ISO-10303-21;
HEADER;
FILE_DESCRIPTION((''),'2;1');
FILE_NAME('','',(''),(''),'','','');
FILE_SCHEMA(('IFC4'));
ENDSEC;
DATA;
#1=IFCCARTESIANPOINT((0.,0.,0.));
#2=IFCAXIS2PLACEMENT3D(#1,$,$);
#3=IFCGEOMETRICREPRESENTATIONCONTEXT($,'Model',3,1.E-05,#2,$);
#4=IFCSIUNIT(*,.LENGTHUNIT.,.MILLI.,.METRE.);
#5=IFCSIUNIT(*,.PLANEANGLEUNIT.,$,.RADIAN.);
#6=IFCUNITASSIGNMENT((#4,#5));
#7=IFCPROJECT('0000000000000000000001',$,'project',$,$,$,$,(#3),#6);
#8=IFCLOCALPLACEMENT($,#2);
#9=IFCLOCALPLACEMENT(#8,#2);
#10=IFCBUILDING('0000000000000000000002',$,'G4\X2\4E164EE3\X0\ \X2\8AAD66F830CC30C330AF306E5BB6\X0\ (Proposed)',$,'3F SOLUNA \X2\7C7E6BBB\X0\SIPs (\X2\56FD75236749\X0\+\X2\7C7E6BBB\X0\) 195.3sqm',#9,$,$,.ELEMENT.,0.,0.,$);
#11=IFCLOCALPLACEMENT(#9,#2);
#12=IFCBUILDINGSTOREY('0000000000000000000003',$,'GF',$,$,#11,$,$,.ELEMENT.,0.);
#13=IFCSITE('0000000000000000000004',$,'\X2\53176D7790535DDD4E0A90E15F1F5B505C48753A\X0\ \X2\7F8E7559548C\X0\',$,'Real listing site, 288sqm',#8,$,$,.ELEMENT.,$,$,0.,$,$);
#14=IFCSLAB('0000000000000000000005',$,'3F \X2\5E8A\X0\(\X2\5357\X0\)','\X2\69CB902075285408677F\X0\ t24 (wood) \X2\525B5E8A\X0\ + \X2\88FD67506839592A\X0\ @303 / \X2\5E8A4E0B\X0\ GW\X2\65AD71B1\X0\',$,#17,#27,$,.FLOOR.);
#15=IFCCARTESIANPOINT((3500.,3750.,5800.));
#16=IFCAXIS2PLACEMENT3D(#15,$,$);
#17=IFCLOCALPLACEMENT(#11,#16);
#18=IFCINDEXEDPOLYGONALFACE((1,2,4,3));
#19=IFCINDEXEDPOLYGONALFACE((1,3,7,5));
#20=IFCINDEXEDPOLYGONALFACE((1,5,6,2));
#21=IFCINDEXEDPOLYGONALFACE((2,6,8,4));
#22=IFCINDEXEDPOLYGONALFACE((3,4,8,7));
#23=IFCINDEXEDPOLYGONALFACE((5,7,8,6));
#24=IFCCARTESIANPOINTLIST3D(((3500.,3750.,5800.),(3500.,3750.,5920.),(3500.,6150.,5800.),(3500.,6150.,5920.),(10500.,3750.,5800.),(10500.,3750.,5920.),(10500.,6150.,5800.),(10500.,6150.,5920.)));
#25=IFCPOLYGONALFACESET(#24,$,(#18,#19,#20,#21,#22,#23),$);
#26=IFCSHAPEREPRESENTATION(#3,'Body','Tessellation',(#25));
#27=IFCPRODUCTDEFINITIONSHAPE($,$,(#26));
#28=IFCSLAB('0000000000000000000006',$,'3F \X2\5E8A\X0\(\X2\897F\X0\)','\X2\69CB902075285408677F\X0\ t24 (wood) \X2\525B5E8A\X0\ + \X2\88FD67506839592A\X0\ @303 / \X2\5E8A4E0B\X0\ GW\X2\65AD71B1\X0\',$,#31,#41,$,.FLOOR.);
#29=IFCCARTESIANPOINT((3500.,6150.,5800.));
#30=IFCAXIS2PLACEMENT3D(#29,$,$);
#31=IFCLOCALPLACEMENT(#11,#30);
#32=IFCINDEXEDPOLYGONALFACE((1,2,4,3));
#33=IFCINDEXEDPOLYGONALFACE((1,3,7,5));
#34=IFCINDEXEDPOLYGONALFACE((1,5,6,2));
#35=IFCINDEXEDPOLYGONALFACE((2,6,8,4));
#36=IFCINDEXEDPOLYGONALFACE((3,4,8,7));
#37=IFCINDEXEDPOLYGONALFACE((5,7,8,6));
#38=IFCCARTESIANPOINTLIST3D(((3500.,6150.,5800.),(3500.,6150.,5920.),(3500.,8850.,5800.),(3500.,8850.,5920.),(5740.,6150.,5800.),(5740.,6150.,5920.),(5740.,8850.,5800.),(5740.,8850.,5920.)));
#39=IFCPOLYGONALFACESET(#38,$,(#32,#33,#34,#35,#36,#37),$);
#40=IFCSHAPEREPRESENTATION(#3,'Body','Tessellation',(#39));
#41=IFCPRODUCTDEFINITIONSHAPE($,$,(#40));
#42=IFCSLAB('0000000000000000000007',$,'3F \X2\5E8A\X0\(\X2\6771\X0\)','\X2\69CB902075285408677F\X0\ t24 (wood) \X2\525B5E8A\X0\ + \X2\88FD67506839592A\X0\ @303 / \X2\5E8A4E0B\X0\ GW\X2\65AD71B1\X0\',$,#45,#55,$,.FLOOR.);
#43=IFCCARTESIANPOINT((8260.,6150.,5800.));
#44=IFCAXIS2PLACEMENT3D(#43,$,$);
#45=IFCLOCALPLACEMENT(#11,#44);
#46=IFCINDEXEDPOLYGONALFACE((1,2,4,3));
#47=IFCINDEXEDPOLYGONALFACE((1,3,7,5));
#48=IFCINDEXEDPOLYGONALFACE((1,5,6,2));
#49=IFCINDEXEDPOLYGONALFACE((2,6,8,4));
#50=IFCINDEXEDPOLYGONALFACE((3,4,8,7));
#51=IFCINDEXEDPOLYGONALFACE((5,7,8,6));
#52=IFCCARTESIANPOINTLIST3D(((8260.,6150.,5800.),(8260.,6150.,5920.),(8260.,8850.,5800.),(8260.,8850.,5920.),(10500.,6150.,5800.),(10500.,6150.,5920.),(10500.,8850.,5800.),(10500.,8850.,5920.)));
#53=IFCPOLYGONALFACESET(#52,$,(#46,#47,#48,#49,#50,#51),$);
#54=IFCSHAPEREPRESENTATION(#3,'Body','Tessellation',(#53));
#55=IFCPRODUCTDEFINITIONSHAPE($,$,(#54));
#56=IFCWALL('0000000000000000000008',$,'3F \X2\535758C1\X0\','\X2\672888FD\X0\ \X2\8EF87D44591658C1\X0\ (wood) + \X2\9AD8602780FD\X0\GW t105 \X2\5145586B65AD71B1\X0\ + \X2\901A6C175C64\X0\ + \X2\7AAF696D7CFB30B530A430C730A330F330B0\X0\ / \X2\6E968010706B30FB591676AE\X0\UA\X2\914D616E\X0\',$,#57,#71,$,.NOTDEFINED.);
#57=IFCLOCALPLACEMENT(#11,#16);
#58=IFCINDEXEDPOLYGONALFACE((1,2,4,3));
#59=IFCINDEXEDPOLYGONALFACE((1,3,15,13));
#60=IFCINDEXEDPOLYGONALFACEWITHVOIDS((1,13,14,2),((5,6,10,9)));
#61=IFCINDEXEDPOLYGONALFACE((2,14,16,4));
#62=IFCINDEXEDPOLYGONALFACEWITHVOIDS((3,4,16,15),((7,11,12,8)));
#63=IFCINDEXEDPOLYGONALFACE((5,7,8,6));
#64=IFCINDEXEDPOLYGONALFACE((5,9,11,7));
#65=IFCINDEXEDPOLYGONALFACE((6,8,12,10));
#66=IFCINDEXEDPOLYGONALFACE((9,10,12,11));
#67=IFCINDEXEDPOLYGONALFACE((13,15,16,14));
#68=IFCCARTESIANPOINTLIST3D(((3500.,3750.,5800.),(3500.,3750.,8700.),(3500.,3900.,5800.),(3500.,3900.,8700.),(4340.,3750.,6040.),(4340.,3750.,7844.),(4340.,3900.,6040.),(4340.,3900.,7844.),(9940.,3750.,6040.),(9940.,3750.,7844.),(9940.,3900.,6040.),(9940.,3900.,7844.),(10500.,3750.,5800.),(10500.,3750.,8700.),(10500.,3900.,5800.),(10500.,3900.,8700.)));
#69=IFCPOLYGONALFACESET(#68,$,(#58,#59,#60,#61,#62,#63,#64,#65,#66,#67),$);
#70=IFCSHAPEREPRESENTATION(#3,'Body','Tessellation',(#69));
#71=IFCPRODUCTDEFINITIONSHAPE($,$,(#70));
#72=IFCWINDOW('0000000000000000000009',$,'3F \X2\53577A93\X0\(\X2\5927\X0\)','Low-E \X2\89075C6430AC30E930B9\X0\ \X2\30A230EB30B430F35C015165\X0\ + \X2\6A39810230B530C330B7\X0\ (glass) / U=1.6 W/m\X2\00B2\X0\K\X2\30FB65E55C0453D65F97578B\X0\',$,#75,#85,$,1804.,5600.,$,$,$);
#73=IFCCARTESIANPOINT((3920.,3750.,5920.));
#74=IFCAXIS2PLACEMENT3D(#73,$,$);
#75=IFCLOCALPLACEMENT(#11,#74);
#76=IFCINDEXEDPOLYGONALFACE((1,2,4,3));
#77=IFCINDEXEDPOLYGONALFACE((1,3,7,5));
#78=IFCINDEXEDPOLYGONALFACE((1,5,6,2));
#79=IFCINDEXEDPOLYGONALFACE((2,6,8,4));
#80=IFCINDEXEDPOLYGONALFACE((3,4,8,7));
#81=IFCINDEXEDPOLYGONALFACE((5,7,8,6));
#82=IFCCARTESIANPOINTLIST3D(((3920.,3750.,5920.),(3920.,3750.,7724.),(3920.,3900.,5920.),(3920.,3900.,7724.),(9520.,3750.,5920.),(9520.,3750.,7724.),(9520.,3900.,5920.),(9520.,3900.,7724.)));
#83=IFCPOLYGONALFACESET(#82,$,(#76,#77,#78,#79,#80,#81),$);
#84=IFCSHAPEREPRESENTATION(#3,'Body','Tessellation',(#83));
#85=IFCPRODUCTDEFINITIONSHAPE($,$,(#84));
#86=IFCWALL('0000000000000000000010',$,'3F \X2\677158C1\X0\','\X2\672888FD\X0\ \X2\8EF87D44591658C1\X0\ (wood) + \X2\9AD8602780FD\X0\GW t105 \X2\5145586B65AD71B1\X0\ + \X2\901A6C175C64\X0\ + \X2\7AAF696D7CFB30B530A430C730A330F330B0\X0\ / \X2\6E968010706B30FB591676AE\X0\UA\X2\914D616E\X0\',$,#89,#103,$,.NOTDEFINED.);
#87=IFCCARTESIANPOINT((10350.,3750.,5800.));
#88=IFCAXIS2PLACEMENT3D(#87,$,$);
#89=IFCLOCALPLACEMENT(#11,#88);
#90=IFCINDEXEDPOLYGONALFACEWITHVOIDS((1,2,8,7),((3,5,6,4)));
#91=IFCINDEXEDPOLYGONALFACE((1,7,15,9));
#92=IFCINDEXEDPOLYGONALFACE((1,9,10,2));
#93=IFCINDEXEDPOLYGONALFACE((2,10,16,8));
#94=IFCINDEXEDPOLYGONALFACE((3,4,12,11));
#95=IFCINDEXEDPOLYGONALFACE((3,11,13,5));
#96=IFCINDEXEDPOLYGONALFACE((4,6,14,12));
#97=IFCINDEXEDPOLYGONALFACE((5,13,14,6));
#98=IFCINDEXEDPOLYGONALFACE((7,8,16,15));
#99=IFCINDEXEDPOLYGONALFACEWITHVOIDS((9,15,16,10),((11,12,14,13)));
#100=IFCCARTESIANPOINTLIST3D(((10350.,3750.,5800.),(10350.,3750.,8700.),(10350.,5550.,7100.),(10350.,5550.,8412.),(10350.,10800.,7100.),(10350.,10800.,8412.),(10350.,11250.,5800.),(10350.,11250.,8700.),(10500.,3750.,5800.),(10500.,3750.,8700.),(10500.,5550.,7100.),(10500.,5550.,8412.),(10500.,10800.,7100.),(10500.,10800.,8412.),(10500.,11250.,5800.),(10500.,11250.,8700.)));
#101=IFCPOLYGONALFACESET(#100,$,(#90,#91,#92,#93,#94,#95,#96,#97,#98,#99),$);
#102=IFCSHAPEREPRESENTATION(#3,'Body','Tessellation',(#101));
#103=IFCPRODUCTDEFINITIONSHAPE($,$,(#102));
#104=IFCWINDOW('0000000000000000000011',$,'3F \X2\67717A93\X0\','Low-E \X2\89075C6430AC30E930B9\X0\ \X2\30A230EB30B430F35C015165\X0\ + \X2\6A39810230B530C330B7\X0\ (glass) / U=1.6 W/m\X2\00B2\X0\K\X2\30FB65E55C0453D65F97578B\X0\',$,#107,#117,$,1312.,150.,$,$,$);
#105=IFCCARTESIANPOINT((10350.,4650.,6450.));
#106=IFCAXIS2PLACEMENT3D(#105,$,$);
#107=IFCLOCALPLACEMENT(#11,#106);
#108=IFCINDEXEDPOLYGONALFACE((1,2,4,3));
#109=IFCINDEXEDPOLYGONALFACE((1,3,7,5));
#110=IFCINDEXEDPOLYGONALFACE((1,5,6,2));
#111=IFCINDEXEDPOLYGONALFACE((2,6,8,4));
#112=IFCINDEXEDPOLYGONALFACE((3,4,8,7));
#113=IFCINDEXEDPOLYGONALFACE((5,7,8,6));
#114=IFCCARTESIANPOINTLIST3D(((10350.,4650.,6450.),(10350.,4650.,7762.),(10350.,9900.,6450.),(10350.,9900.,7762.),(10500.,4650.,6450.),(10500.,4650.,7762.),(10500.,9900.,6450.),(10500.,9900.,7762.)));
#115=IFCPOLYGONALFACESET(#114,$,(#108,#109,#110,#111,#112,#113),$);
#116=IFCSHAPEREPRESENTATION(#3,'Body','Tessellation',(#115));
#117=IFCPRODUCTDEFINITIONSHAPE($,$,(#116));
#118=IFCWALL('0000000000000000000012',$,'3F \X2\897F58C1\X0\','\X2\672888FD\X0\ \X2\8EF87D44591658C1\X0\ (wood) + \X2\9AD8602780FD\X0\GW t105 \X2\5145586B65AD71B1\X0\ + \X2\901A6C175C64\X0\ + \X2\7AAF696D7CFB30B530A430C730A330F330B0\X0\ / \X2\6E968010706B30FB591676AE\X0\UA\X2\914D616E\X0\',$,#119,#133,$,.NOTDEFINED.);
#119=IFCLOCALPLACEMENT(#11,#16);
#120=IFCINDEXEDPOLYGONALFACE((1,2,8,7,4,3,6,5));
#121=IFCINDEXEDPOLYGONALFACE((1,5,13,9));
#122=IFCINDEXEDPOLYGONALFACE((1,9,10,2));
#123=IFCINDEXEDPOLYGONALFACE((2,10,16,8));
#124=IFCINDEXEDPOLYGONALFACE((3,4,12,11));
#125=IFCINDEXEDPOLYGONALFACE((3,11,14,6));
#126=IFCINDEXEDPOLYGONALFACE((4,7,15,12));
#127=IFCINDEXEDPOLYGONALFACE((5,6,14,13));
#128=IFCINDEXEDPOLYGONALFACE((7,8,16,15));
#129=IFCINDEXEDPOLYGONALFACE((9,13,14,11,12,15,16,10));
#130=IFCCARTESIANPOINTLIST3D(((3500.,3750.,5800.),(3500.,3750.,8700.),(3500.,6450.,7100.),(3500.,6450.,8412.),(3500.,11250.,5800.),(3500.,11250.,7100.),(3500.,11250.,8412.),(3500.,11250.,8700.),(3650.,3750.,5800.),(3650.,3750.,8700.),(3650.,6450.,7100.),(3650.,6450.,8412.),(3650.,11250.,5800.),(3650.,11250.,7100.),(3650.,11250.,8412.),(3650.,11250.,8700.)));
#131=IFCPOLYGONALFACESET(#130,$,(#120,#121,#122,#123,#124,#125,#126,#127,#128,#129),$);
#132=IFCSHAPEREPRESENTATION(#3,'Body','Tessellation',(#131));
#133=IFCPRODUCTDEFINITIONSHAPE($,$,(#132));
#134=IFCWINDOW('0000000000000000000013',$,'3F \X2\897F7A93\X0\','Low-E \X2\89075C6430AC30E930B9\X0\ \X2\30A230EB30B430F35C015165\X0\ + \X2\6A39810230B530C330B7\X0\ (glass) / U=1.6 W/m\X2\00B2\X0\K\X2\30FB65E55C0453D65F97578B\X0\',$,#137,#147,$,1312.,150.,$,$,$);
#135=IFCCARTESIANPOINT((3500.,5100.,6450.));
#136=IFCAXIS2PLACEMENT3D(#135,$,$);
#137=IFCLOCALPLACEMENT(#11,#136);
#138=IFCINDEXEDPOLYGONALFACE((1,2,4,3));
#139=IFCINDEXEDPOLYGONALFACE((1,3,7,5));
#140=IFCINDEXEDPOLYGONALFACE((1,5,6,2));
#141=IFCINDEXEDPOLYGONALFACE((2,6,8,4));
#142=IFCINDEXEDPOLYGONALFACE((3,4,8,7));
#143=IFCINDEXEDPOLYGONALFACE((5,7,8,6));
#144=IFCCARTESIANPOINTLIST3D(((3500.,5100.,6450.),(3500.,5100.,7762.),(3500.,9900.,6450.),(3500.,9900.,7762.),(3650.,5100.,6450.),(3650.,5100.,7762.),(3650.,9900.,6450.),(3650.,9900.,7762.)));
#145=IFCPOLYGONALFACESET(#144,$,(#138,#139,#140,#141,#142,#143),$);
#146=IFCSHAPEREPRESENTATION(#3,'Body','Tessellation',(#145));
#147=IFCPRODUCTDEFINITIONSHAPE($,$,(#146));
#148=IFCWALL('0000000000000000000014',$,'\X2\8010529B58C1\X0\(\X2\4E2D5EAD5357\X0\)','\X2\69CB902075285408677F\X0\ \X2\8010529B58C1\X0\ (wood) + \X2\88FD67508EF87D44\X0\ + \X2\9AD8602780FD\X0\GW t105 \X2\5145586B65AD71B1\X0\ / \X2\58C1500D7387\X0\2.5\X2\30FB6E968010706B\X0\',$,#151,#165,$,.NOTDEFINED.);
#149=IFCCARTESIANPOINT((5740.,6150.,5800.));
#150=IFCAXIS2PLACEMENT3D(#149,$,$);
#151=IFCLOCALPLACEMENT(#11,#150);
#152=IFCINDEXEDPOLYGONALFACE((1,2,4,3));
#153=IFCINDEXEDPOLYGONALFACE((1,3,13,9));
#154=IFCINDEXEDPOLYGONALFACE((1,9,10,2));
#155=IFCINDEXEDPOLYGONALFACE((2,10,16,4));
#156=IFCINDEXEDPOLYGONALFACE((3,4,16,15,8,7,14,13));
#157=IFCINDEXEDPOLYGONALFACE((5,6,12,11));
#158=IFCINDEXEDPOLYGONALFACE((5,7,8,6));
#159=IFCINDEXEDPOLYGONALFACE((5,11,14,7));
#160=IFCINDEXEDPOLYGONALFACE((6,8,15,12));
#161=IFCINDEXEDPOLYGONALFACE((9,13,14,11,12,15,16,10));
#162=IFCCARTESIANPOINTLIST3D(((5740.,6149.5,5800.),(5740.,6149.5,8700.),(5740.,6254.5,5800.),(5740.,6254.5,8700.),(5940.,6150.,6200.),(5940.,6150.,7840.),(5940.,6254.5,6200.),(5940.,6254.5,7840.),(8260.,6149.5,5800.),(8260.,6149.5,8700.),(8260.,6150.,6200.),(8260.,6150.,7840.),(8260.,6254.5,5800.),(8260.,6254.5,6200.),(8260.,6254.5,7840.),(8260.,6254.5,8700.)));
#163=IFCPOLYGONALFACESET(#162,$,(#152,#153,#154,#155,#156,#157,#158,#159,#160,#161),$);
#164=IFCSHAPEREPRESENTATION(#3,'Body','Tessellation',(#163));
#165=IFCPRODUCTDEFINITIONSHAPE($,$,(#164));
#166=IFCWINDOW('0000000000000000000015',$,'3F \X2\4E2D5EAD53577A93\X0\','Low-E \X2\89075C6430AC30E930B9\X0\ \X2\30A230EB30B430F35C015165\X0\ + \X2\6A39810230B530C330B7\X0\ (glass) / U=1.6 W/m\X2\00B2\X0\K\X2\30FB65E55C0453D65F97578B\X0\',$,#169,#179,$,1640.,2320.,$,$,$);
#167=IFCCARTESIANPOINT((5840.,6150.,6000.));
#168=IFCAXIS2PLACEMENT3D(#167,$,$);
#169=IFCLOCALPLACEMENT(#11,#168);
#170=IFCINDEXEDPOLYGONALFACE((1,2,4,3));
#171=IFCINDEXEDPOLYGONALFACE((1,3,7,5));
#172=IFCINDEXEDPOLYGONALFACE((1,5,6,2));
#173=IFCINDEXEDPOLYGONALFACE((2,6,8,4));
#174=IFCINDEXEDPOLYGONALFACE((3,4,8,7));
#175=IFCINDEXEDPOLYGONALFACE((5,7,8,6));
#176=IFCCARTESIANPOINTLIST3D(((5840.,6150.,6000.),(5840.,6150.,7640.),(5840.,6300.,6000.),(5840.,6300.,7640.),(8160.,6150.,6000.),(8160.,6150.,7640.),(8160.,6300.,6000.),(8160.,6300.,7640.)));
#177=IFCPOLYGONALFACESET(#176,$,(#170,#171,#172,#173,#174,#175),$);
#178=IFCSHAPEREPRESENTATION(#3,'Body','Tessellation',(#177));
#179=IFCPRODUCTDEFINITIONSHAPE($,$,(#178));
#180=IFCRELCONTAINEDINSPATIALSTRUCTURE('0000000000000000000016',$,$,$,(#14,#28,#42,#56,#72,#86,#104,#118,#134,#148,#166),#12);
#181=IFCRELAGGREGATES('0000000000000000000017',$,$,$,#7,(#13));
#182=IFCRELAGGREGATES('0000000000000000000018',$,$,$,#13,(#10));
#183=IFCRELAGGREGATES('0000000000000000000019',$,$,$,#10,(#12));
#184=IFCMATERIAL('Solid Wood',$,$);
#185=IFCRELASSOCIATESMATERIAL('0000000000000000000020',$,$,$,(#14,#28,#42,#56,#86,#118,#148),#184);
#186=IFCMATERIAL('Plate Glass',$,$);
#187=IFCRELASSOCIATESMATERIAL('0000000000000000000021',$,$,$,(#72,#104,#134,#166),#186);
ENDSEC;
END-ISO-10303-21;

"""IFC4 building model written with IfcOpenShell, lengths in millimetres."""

from ifc_helpers import new_model, si_unit, frame, frame_2d, origin, place, context, project, spatial, rectangle, extrude, material, element, fill, save


model = new_model("IFC4")

# Units and contexts
model_context = context("Model", 3, precision=1e-05, world=origin())
ifc_project = project(units=[si_unit("LENGTHUNIT", "METRE", prefix="MILLI"), si_unit("PLANEANGLEUNIT", "RADIAN")], contexts=[model_context])

# Site, building, storey
site_placement = place(None, origin())
site = spatial("IfcSite", under=ifc_project, at=site_placement, Name="北海道川上郡弟子屈町 美留和", ObjectType="Real listing site, 288sqm", CompositionType="ELEMENT", RefElevation=0.0)
building_placement = place(site_placement, origin())
building = spatial("IfcBuilding", under=site, at=building_placement, Name="G4世代 読書ヌックの家 (Proposed)", ObjectType="3F SOLUNA 籾殻SIPs (国産杉+籾殻) 195.3sqm", CompositionType="ELEMENT", ElevationOfRefHeight=0.0, ElevationOfTerrain=0.0)
storey_placement = place(building_placement, origin())
storey = spatial("IfcBuildingStorey", under=building, at=storey_placement, Name="GF", CompositionType="ELEMENT", Elevation=0.0)

# Slabs
ifc_material_1 = material(Name="Solid Wood")
slab_1_placement = place(storey_placement, frame((3500.0, 3750.0, 5800.0)))
element("IfcSlab", 1, at=slab_1_placement, inside=storey, material=ifc_material_1, Name="3F 床(南)", Description="構造用合板 t24 (wood) 剛床 + 製材根太 @303 / 床下 GW断熱", PredefinedType="FLOOR", context=model_context, shape_type="SweptSolid", body=[
    extrude(rectangle(XDim=7000.0, YDim=2400.0, at=frame_2d((3500.0, 1200.0))), frame((3500.0, 3750.0, 5800.0)), (0.0, 0.0, 1.0), 120.0),
])
slab_2_placement = place(storey_placement, frame((3500.0, 6150.0, 5800.0)))
element("IfcSlab", 2, at=slab_2_placement, inside=storey, material=ifc_material_1, Name="3F 床(西)", Description="構造用合板 t24 (wood) 剛床 + 製材根太 @303 / 床下 GW断熱", PredefinedType="FLOOR", context=model_context, shape_type="SweptSolid", body=[
    extrude(rectangle(XDim=2240.0, YDim=2700.0, at=frame_2d((1120.0, 1350.0))), frame((3500.0, 6150.0, 5800.0)), (0.0, 0.0, 1.0), 120.0),
])
slab_3_placement = place(storey_placement, frame((8260.0, 6150.0, 5800.0)))
element("IfcSlab", 3, at=slab_3_placement, inside=storey, material=ifc_material_1, Name="3F 床(東)", Description="構造用合板 t24 (wood) 剛床 + 製材根太 @303 / 床下 GW断熱", PredefinedType="FLOOR", context=model_context, shape_type="SweptSolid", body=[
    extrude(rectangle(XDim=2240.0, YDim=2700.0, at=frame_2d((1120.0, 1350.0))), frame((8260.0, 6150.0, 5800.0)), (0.0, 0.0, 1.0), 120.0),
])

# Walls, openings, windows
wall_1_placement = place(storey_placement, frame((3500.0, 3750.0, 5800.0)))
wall_1 = element("IfcWall", 4, at=wall_1_placement, inside=storey, material=ifc_material_1, Name="3F 南壁", Description="木製 軸組外壁 (wood) + 高性能GW t105 充填断熱 + 通気層 + 窯業系サイディング / 準耐火・外皮UA配慮", PredefinedType="NOTDEFINED", context=model_context, shape_type="SweptSolid", body=[
    extrude(rectangle(XDim=7000.0, YDim=150.0, at=frame_2d((3500.0, 75.0))), frame((3500.0, 3750.0, 5800.0)), (0.0, 0.0, 1.0), 2900.0),
])
opening_1_placement = place(storey_placement, frame((3920.0, 3750.0, 5920.0)))
opening_1 = element("IfcOpeningElement", 5, at=opening_1_placement, cuts=wall_1, PredefinedType="NOTDEFINED", context=model_context, shape_type="SweptSolid", body=[
    extrude(rectangle(XDim=5600.0, YDim=150.0, at=frame_2d((2800.0, 75.0))), frame((3920.0, 3750.0, 5920.0)), (0.0, 0.0, 1.0), 1804.0),
])
ifc_material_2 = material(Name="Plate Glass")
window_1_placement = place(storey_placement, frame((3920.0, 3750.0, 5920.0)))
window_1 = element("IfcWindow", 6, at=window_1_placement, inside=storey, material=ifc_material_2, Name="3F 南窓(大)", Description="Low-E 複層ガラス アルゴン封入 + 樹脂サッシ (glass) / U=1.6 W/m²K・日射取得型", OverallHeight=1804.0, OverallWidth=5600.0, context=model_context, shape_type="SweptSolid", body=[
    extrude(rectangle(XDim=5600.0, YDim=150.0, at=frame_2d((2800.0, 75.0))), frame((3920.0, 3750.0, 5920.0)), (0.0, 0.0, 1.0), 1804.0),
])
fill(opening_1, window_1)
wall_2_placement = place(storey_placement, frame((10350.0, 3750.0, 5800.0)))
wall_2 = element("IfcWall", 7, at=wall_2_placement, inside=storey, material=ifc_material_1, Name="3F 東壁", Description="木製 軸組外壁 (wood) + 高性能GW t105 充填断熱 + 通気層 + 窯業系サイディング / 準耐火・外皮UA配慮", PredefinedType="NOTDEFINED", context=model_context, shape_type="SweptSolid", body=[
    extrude(rectangle(XDim=150.0, YDim=7500.0, at=frame_2d((75.0, 3750.0))), frame((10350.0, 3750.0, 5800.0)), (0.0, 0.0, 1.0), 2900.0),
])
opening_2_placement = place(storey_placement, frame((10350.0, 4650.0, 6450.0)))
opening_2 = element("IfcOpeningElement", 8, at=opening_2_placement, cuts=wall_2, PredefinedType="NOTDEFINED", context=model_context, shape_type="SweptSolid", body=[
    extrude(rectangle(XDim=150.0, YDim=5250.0, at=frame_2d((75.0, 2625.0))), frame((10350.0, 4650.0, 6450.0)), (0.0, 0.0, 1.0), 1312.0),
])
window_2_placement = place(storey_placement, frame((10350.0, 4650.0, 6450.0)))
window_2 = element("IfcWindow", 9, at=window_2_placement, inside=storey, material=ifc_material_2, Name="3F 東窓", Description="Low-E 複層ガラス アルゴン封入 + 樹脂サッシ (glass) / U=1.6 W/m²K・日射取得型", OverallHeight=1312.0, OverallWidth=150.0, context=model_context, shape_type="SweptSolid", body=[
    extrude(rectangle(XDim=150.0, YDim=5250.0, at=frame_2d((75.0, 2625.0))), frame((10350.0, 4650.0, 6450.0)), (0.0, 0.0, 1.0), 1312.0),
])
fill(opening_2, window_2)
wall_3_placement = place(storey_placement, frame((3500.0, 3750.0, 5800.0)))
wall_3 = element("IfcWall", 10, at=wall_3_placement, inside=storey, material=ifc_material_1, Name="3F 西壁", Description="木製 軸組外壁 (wood) + 高性能GW t105 充填断熱 + 通気層 + 窯業系サイディング / 準耐火・外皮UA配慮", PredefinedType="NOTDEFINED", context=model_context, shape_type="SweptSolid", body=[
    extrude(rectangle(XDim=150.0, YDim=7500.0, at=frame_2d((75.0, 3750.0))), frame((3500.0, 3750.0, 5800.0)), (0.0, 0.0, 1.0), 2900.0),
])
opening_3_placement = place(storey_placement, frame((3500.0, 5100.0, 6450.0)))
opening_3 = element("IfcOpeningElement", 11, at=opening_3_placement, cuts=wall_3, PredefinedType="NOTDEFINED", context=model_context, shape_type="SweptSolid", body=[
    extrude(rectangle(XDim=150.0, YDim=4800.0, at=frame_2d((75.0, 2400.0))), frame((3500.0, 5100.0, 6450.0)), (0.0, 0.0, 1.0), 1312.0),
])
window_3_placement = place(storey_placement, frame((3500.0, 5100.0, 6450.0)))
window_3 = element("IfcWindow", 12, at=window_3_placement, inside=storey, material=ifc_material_2, Name="3F 西窓", Description="Low-E 複層ガラス アルゴン封入 + 樹脂サッシ (glass) / U=1.6 W/m²K・日射取得型", OverallHeight=1312.0, OverallWidth=150.0, context=model_context, shape_type="SweptSolid", body=[
    extrude(rectangle(XDim=150.0, YDim=4800.0, at=frame_2d((75.0, 2400.0))), frame((3500.0, 5100.0, 6450.0)), (0.0, 0.0, 1.0), 1312.0),
])
fill(opening_3, window_3)
wall_4_placement = place(storey_placement, frame((5740.0, 6150.0, 5800.0)))
wall_4 = element("IfcWall", 13, at=wall_4_placement, inside=storey, material=ifc_material_1, Name="耐力壁(中庭南)", Description="構造用合板 耐力壁 (wood) + 製材軸組 + 高性能GW t105 充填断熱 / 壁倍率2.5・準耐火", PredefinedType="NOTDEFINED", context=model_context, shape_type="SweptSolid", body=[
    extrude(rectangle(XDim=2520.0, YDim=105.0, at=frame_2d((1260.0, 52.0))), frame((5740.0, 6150.0, 5800.0)), (0.0, 0.0, 1.0), 2900.0),
])
opening_4_placement = place(storey_placement, frame((5840.0, 6150.0, 6000.0)))
opening_4 = element("IfcOpeningElement", 14, at=opening_4_placement, cuts=wall_4, PredefinedType="NOTDEFINED", context=model_context, shape_type="SweptSolid", body=[
    extrude(rectangle(XDim=2320.0, YDim=150.0, at=frame_2d((1160.0, 75.0))), frame((5840.0, 6150.0, 6000.0)), (0.0, 0.0, 1.0), 1640.0),
])
window_4_placement = place(storey_placement, frame((5840.0, 6150.0, 6000.0)))
window_4 = element("IfcWindow", 15, at=window_4_placement, inside=storey, material=ifc_material_2, Name="3F 中庭南窓", Description="Low-E 複層ガラス アルゴン封入 + 樹脂サッシ (glass) / U=1.6 W/m²K・日射取得型", OverallHeight=1640.0, OverallWidth=2320.0, context=model_context, shape_type="SweptSolid", body=[
    extrude(rectangle(XDim=2320.0, YDim=150.0, at=frame_2d((1160.0, 75.0))), frame((5840.0, 6150.0, 6000.0)), (0.0, 0.0, 1.0), 1640.0),
])
fill(opening_4, window_4)

save(model, "model.ifc")
